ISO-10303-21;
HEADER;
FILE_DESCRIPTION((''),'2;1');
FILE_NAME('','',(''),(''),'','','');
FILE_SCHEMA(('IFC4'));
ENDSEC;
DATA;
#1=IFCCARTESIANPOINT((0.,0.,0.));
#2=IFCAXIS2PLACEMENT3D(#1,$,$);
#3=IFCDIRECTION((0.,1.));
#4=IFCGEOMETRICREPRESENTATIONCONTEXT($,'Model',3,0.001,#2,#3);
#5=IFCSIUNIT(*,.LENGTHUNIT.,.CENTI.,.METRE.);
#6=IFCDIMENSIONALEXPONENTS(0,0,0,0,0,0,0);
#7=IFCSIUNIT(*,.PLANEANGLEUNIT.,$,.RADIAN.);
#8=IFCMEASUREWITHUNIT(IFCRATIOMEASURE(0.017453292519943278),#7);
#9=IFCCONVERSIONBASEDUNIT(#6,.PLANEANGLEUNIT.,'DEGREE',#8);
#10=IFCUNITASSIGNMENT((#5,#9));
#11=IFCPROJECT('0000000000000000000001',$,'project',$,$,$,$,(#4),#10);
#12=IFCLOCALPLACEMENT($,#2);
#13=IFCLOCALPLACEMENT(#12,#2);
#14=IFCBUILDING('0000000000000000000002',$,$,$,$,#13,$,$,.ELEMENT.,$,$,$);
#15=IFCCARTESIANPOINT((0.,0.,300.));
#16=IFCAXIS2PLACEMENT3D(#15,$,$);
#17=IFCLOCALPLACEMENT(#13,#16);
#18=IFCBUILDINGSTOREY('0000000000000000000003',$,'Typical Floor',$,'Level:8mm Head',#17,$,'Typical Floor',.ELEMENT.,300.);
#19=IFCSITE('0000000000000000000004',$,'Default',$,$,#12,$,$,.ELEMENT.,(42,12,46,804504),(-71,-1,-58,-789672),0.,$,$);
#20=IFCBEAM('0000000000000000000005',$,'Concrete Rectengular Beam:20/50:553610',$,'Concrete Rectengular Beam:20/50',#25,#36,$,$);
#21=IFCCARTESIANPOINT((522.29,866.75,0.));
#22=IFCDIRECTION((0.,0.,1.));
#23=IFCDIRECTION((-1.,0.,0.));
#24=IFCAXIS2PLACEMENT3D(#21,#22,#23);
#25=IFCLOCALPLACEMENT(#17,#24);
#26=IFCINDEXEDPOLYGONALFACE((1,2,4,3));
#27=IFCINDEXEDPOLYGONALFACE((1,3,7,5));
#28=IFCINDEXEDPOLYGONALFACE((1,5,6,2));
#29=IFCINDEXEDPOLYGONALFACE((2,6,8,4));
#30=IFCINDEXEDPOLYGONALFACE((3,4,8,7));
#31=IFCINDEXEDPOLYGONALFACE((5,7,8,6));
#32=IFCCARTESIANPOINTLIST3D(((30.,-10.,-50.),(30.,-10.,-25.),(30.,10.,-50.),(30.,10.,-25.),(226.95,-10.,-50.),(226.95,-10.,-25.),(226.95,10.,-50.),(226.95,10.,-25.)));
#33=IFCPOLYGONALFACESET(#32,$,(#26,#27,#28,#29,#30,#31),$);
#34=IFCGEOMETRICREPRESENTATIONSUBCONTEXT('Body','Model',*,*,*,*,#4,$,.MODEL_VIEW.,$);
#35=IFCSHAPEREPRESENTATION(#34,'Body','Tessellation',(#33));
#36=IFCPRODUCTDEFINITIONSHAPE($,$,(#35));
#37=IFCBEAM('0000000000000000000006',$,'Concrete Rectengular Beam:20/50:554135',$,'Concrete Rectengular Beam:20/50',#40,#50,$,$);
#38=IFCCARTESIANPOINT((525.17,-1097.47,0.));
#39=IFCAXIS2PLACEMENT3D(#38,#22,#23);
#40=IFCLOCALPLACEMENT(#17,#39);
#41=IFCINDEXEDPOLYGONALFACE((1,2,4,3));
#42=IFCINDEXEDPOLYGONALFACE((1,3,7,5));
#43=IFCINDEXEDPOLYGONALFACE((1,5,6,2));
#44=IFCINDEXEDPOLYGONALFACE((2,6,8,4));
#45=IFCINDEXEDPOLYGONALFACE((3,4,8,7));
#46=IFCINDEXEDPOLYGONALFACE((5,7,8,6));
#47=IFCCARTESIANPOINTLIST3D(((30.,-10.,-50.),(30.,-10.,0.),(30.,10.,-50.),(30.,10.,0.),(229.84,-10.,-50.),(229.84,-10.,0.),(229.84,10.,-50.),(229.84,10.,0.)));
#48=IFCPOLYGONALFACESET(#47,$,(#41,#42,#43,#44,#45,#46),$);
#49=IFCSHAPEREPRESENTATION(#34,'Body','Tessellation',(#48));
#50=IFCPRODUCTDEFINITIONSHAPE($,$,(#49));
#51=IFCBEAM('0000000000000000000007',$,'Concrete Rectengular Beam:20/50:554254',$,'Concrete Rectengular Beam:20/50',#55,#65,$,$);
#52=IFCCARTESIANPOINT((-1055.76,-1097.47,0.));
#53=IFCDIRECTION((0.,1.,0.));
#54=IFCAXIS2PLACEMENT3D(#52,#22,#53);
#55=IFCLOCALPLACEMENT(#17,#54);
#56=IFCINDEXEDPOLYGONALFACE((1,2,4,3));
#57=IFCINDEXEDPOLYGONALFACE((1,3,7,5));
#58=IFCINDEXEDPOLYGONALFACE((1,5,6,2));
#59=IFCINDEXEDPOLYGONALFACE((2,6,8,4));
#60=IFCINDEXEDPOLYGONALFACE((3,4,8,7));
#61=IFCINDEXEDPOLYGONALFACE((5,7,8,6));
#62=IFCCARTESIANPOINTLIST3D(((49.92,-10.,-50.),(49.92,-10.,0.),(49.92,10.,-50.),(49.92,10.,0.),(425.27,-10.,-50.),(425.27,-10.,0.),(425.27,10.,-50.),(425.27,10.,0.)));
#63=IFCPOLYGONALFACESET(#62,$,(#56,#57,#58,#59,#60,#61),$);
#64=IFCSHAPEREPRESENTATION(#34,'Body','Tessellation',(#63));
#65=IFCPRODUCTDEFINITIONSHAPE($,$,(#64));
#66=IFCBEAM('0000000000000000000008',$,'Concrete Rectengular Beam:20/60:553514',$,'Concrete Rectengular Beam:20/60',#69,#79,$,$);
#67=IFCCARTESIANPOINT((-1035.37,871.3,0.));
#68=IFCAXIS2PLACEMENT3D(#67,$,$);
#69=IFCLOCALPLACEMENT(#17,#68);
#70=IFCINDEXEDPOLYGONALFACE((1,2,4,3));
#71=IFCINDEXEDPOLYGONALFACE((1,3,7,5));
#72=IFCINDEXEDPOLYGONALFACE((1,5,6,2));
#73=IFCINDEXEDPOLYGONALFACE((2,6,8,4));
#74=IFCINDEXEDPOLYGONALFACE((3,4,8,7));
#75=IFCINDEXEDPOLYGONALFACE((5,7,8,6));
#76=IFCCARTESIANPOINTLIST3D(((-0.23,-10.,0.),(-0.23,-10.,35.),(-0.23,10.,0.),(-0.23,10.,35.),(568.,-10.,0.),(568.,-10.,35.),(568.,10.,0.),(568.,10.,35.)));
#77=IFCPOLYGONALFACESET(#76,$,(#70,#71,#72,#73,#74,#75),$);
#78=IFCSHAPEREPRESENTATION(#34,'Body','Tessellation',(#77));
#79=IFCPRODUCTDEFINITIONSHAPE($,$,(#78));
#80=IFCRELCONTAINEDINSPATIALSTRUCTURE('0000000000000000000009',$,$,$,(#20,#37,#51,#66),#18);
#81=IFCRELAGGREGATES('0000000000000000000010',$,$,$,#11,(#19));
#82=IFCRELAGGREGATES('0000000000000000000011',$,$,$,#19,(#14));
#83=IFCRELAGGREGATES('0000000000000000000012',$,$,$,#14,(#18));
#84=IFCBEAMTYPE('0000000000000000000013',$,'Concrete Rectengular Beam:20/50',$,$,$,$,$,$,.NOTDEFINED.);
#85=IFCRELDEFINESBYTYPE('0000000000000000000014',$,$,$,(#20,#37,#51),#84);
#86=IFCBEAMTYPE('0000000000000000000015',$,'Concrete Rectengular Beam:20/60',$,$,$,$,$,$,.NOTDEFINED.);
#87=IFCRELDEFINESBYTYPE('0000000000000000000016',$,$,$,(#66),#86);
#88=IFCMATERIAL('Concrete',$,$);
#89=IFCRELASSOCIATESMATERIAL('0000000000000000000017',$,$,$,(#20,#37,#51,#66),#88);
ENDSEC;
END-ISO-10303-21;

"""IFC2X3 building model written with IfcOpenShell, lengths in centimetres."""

from ifc_helpers import new_model, entity, si_unit, converted_unit, direction, frame, frame_2d, origin, place, context, subcontext, project, spatial, rectangle, extrude, material, type_object, element, save


model = new_model("IFC2X3")

# Units and contexts
model_context = context("Model", 3, precision=0.001, world=origin(), true_north=direction((0.0, 1.0)))
body_context = subcontext(model_context, "Body", "Model", "MODEL_VIEW")
ifc_project = project(units=[si_unit("LENGTHUNIT", "METRE", prefix="CENTI"), converted_unit("PLANEANGLEUNIT", "DEGREE", entity("IfcRatioMeasure", 0.017453292519943278), si_unit("PLANEANGLEUNIT", "RADIAN"), dimensions=[0, 0, 0, 0, 0, 0, 0])], contexts=[model_context])

# Site, building, storey
site_placement = place(None, origin())
site = spatial("IfcSite", under=ifc_project, at=site_placement, Name="Default", CompositionType="ELEMENT", RefLatitude=(42, 12, 46, 804504), RefLongitude=(-71, -1, -58, -789672), RefElevation=0.0)
building_placement = place(site_placement, origin())
building = spatial("IfcBuilding", under=site, at=building_placement, CompositionType="ELEMENT")
storey_placement = place(building_placement, frame((0.0, 0.0, 300.0)))
storey = spatial("IfcBuildingStorey", under=building, at=storey_placement, Name="Typical Floor", ObjectType="Level:8mm Head", LongName="Typical Floor", CompositionType="ELEMENT", Elevation=300.0)

# Beams
ifc_material = material(Name="Concrete")
beam_type_1 = type_object("IfcBeamType", Name="Concrete Rectengular Beam:20/50", PredefinedType="NOTDEFINED")
beam_1_placement = place(storey_placement, frame((522.29, 866.75, 0.0), z_axis=(0.0, 0.0, 1.0), x_axis=(-1.0, 0.0, 0.0)))
element("IfcBeam", 1, at=beam_1_placement, inside=storey, type_object=beam_type_1, material=ifc_material, Name="Concrete Rectengular Beam:20/50:553610", ObjectType="Concrete Rectengular Beam:20/50", context=body_context, shape_type="SweptSolid", body=[
    extrude(rectangle(XDim=25.0, YDim=20.0, at=frame_2d((0.0, 0.0), x_axis=(1.0, 0.0))), frame((30.0, 0.0, -37.5), z_axis=(1.0, 0.0, 0.0), x_axis=(0.0, 0.0, -1.0)), (0.0, 0.0, 1.0), 196.95),
])
beam_2_placement = place(storey_placement, frame((525.17, -1097.47, 0.0), z_axis=(0.0, 0.0, 1.0), x_axis=(-1.0, 0.0, 0.0)))
element("IfcBeam", 2, at=beam_2_placement, inside=storey, type_object=beam_type_1, material=ifc_material, Name="Concrete Rectengular Beam:20/50:554135", ObjectType="Concrete Rectengular Beam:20/50", context=body_context, shape_type="SweptSolid", body=[
    extrude(rectangle(XDim=50.0, YDim=20.0, at=frame_2d((0.0, 0.0), x_axis=(1.0, 0.0))), frame((30.0, 0.0, -25.0), z_axis=(1.0, 0.0, 0.0), x_axis=(0.0, 0.0, -1.0)), (0.0, 0.0, 1.0), 199.84),
])
beam_3_placement = place(storey_placement, frame((-1055.76, -1097.47, 0.0), z_axis=(0.0, 0.0, 1.0), x_axis=(0.0, 1.0, 0.0)))
element("IfcBeam", 3, at=beam_3_placement, inside=storey, type_object=beam_type_1, material=ifc_material, Name="Concrete Rectengular Beam:20/50:554254", ObjectType="Concrete Rectengular Beam:20/50", context=body_context, shape_type="SweptSolid", body=[
    extrude(rectangle(XDim=50.0, YDim=20.0, at=frame_2d((0.0, 0.0), x_axis=(1.0, 0.0))), frame((49.92, 0.0, -25.0), z_axis=(1.0, 0.0, 0.0), x_axis=(0.0, 0.0, -1.0)), (0.0, 0.0, 1.0), 375.35),
])
beam_type_2 = type_object("IfcBeamType", Name="Concrete Rectengular Beam:20/60", PredefinedType="NOTDEFINED")
beam_4_placement = place(storey_placement, frame((-1035.37, 871.3, 0.0)))
element("IfcBeam", 4, at=beam_4_placement, inside=storey, type_object=beam_type_2, material=ifc_material, Name="Concrete Rectengular Beam:20/60:553514", ObjectType="Concrete Rectengular Beam:20/60", context=body_context, shape_type="SweptSolid", body=[
    extrude(rectangle(XDim=35.0, YDim=20.0, at=frame_2d((0.0, 0.0), x_axis=(1.0, 0.0))), frame((-0.23, 0.0, 17.5), z_axis=(1.0, 0.0, 0.0), x_axis=(0.0, 0.0, -1.0)), (0.0, 0.0, 1.0), 568.23),
])

save(model, "model.ifc")
